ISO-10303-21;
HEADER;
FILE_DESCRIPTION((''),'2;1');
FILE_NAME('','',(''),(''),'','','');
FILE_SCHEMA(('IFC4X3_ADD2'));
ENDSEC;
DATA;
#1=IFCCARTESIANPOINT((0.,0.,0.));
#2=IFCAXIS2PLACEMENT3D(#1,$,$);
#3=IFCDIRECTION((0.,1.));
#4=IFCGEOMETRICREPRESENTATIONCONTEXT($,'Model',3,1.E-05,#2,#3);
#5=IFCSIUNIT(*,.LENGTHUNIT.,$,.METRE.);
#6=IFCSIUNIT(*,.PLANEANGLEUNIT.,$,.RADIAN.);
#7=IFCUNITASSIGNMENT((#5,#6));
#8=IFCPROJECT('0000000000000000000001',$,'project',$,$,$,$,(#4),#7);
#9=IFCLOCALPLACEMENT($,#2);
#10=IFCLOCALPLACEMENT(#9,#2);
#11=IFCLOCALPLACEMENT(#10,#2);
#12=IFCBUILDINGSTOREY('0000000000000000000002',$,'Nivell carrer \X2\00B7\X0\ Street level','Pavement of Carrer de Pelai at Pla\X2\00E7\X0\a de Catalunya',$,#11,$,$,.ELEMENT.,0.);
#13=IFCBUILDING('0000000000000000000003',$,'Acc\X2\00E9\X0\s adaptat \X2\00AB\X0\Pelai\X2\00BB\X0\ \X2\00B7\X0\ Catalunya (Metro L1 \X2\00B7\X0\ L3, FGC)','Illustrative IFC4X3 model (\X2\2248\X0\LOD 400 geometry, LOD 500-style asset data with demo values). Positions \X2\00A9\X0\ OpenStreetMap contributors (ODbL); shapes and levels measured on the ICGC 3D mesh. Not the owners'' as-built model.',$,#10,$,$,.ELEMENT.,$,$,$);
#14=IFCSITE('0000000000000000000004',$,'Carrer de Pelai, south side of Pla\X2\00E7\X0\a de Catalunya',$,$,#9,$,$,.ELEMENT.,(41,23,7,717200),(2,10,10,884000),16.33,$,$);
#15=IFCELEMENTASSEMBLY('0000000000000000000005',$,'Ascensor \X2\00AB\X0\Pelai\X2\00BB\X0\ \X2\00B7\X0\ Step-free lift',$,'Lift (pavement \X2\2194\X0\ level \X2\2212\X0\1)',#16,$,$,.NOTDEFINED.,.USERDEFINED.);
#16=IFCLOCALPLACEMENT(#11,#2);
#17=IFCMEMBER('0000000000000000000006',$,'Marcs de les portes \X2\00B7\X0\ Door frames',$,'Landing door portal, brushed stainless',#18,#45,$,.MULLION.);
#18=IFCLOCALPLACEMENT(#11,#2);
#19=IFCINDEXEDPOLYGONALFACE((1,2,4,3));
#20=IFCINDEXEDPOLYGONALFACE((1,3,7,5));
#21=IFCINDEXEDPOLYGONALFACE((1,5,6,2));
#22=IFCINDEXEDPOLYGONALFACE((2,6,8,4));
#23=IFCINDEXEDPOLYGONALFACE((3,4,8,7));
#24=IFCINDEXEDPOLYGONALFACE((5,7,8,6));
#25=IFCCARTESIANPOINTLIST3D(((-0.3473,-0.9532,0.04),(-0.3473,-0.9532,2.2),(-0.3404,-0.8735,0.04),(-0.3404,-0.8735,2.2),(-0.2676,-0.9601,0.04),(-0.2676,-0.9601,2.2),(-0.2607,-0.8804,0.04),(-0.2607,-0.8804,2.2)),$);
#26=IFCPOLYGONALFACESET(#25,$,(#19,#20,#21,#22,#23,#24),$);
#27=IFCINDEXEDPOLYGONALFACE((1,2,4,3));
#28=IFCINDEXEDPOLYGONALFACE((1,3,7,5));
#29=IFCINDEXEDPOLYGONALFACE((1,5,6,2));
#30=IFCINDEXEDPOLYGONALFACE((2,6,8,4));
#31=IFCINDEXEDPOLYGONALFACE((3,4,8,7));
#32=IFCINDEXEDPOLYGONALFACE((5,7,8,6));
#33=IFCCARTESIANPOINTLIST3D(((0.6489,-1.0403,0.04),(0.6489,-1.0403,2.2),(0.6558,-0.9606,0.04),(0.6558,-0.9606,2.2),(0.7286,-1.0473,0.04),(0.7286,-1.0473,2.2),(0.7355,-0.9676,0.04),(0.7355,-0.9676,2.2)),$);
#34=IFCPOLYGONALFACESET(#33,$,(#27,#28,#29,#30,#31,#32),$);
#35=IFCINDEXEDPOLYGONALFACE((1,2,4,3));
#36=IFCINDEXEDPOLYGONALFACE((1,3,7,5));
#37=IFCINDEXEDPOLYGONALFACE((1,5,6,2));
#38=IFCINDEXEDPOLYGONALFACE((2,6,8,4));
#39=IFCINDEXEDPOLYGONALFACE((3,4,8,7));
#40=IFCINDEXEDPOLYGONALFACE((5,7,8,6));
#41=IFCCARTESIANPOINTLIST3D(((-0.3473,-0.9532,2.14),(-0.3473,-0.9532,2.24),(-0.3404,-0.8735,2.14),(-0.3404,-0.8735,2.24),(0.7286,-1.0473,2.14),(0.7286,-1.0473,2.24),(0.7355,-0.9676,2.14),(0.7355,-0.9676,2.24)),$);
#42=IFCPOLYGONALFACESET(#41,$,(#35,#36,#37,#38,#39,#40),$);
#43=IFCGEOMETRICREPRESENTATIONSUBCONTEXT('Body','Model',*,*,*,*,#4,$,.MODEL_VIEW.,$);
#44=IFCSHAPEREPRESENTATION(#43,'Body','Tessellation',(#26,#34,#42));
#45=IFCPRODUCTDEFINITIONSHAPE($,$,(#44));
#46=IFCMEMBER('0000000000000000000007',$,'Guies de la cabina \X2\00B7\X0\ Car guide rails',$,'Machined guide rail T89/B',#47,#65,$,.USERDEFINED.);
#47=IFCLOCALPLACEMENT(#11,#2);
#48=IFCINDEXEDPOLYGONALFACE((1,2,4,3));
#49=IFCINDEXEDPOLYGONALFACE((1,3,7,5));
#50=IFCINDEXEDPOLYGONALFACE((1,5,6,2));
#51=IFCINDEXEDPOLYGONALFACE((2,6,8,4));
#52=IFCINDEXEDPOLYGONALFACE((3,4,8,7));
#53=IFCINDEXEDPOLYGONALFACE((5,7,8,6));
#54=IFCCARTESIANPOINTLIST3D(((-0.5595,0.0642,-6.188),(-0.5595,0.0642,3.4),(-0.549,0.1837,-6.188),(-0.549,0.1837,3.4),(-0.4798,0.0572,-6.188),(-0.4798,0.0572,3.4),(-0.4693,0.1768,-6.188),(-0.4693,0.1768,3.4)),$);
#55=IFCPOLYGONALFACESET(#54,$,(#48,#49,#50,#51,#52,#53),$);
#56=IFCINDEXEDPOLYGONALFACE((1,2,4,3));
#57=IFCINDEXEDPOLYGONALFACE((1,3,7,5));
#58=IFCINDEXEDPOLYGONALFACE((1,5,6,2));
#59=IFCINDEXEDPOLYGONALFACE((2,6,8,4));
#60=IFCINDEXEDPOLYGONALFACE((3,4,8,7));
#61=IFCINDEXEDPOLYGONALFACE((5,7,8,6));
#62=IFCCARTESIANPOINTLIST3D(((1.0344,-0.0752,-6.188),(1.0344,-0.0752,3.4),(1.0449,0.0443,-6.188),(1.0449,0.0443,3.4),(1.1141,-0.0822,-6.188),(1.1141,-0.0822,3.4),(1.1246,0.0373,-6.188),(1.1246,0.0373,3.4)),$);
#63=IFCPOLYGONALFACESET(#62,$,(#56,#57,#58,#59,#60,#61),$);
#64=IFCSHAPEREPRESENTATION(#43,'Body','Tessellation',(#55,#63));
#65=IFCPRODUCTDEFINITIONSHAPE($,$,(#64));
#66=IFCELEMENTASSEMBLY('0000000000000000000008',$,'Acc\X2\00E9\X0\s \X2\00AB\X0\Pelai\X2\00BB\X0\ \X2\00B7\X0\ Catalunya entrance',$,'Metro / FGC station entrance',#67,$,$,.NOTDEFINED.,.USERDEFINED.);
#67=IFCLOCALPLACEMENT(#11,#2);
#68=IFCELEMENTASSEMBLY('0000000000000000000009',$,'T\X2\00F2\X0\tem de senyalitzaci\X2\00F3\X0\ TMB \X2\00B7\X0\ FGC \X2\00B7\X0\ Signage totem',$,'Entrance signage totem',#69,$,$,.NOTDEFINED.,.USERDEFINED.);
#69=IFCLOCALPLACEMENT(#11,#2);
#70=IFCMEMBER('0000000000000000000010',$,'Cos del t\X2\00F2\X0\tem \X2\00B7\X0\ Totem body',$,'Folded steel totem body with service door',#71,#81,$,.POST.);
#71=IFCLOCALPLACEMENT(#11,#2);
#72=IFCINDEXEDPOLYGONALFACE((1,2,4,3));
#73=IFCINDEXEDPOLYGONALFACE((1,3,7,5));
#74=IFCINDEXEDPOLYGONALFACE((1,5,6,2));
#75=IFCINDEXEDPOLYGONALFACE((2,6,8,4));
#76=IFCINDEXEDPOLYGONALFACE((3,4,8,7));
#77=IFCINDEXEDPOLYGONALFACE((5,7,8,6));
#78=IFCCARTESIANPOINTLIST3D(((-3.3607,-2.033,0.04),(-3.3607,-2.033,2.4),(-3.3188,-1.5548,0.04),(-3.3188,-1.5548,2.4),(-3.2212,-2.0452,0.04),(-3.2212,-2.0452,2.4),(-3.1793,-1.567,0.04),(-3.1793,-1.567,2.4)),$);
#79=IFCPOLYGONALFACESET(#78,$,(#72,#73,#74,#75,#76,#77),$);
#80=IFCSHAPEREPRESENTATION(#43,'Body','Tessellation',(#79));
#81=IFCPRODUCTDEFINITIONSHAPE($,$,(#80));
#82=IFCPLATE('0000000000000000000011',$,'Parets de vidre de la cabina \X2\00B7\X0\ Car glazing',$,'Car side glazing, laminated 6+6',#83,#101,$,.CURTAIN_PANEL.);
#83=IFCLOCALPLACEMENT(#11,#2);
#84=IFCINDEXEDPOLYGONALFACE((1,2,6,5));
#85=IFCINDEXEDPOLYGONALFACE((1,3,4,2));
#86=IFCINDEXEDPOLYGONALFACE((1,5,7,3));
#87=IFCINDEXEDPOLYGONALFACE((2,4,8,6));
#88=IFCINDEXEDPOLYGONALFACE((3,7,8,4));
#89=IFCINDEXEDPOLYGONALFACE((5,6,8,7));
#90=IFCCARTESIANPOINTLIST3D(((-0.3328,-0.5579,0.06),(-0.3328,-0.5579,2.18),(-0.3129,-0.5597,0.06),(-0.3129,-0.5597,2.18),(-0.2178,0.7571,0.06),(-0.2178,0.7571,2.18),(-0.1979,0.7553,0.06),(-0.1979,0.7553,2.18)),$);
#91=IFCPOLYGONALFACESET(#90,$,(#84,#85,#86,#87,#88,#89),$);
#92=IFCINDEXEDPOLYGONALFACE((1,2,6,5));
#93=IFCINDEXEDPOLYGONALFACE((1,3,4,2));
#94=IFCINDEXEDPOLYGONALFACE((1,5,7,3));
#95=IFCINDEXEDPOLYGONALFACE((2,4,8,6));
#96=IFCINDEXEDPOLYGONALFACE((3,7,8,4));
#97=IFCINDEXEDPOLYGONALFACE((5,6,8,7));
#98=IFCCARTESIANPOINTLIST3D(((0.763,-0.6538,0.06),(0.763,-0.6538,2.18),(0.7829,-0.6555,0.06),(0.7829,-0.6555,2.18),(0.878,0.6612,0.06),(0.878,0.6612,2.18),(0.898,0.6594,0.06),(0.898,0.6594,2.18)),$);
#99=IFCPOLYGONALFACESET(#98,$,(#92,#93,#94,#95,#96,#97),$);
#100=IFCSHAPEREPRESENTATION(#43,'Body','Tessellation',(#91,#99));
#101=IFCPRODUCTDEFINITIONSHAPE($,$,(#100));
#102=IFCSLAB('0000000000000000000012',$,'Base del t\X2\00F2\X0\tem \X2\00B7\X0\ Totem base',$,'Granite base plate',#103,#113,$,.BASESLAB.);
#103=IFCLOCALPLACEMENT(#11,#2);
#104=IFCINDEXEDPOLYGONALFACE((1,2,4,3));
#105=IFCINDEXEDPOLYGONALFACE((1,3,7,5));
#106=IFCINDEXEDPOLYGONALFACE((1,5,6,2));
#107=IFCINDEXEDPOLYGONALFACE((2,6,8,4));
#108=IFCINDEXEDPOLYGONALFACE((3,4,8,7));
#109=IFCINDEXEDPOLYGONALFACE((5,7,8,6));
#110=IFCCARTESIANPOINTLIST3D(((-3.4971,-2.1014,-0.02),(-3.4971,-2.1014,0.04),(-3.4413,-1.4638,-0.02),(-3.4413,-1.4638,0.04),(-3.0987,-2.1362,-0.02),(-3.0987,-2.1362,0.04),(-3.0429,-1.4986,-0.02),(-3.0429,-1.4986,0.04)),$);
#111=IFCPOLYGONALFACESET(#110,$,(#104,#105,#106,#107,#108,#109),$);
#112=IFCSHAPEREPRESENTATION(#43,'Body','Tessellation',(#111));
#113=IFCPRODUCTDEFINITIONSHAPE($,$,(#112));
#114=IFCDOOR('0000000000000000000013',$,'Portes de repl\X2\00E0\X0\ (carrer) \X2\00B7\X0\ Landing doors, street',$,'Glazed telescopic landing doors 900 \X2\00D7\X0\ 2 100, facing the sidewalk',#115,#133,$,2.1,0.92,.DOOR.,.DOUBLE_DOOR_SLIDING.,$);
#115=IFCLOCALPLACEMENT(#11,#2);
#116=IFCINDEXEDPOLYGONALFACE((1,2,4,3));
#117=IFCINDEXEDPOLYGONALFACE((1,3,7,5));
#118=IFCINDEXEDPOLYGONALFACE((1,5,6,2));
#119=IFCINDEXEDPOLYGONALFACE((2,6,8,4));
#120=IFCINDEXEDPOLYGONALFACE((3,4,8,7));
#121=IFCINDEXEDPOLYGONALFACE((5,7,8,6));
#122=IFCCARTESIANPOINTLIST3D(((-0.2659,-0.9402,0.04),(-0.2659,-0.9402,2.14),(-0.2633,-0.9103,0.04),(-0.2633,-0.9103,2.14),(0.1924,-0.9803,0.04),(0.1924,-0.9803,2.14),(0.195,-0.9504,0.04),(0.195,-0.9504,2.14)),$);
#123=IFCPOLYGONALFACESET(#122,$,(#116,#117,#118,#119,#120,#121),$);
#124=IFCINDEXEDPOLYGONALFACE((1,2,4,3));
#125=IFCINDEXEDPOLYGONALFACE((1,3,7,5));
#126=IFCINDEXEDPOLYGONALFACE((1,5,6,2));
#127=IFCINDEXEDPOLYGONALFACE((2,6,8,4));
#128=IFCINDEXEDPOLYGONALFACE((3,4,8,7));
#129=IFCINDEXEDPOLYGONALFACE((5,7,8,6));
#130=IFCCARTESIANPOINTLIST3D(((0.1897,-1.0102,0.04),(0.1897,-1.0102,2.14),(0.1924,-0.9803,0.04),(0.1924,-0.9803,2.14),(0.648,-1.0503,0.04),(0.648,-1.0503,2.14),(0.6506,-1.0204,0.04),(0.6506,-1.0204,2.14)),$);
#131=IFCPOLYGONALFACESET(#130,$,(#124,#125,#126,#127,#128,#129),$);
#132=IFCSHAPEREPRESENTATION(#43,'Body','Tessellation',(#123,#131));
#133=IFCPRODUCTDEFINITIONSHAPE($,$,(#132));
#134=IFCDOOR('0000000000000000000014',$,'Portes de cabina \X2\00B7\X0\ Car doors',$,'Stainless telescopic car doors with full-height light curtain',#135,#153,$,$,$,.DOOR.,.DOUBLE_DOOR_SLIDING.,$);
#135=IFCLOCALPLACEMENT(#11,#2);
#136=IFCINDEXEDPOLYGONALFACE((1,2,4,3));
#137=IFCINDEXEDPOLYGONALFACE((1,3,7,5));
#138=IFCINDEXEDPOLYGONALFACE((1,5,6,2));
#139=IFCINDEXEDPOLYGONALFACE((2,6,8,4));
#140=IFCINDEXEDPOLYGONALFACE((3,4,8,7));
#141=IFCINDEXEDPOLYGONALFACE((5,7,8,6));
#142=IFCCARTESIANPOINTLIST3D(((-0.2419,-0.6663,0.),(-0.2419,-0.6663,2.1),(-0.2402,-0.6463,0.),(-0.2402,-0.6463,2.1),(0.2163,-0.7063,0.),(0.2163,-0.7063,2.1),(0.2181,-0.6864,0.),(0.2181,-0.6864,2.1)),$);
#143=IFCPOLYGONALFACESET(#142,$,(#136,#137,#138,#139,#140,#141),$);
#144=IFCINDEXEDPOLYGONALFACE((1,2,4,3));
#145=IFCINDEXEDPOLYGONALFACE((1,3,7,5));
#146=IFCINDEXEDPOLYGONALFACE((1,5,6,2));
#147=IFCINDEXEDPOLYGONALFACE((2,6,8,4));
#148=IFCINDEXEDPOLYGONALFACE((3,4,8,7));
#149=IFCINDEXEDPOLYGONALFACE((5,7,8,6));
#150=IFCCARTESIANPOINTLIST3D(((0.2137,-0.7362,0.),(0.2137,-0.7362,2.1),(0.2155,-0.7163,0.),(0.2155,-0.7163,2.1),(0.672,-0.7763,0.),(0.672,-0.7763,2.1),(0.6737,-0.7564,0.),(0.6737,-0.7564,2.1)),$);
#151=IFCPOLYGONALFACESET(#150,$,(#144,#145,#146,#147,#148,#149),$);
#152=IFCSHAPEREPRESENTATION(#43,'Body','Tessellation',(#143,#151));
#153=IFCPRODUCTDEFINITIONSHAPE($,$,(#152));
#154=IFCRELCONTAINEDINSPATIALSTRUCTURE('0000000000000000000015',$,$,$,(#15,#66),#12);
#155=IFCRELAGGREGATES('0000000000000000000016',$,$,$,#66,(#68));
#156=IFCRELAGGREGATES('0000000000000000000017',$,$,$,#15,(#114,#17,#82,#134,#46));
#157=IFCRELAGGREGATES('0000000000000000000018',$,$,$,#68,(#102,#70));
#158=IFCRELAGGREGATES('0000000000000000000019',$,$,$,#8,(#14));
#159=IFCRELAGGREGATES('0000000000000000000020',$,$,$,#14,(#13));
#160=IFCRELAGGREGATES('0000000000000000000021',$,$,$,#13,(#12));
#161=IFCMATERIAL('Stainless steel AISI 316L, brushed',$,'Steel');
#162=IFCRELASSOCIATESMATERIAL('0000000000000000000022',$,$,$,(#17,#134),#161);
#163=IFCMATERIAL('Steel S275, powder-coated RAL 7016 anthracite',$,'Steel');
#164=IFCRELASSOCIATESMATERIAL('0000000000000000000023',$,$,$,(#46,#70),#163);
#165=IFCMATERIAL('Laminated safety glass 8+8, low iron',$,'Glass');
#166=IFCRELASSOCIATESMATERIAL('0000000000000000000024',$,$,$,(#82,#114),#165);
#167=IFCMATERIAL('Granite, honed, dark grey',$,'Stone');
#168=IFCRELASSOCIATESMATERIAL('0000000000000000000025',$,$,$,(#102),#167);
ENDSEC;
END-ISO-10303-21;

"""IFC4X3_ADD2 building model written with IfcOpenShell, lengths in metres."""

from ifc_helpers import new_model, si_unit, direction, frame, frame_2d, origin, place, context, subcontext, project, spatial, rectangle, extrude, material, element, aggregate, save


model = new_model("IFC4X3_ADD2")

# Units and contexts
model_context = context("Model", 3, precision=1e-05, world=origin(), true_north=direction((0.0, 1.0)))
body_context = subcontext(model_context, "Body", "Model", "MODEL_VIEW")
ifc_project = project(units=[si_unit("LENGTHUNIT", "METRE"), si_unit("PLANEANGLEUNIT", "RADIAN")], contexts=[model_context])

# Site, building, storey
site_placement = place(None, origin())
site = spatial("IfcSite", under=ifc_project, at=site_placement, Name="Carrer de Pelai, south side of Plaça de Catalunya", CompositionType="ELEMENT", RefLatitude=(41, 23, 7, 717200), RefLongitude=(2, 10, 10, 884000), RefElevation=16.33)
building_placement = place(site_placement, origin())
building = spatial("IfcBuilding", under=site, at=building_placement, Name="Accés adaptat «Pelai» · Catalunya (Metro L1 · L3, FGC)", Description="Illustrative IFC4X3 model (≈LOD 400 geometry, LOD 500-style asset data with demo values). Positions © OpenStreetMap contributors (ODbL); shapes and levels measured on the ICGC 3D mesh. Not the owners' as-built model.", CompositionType="ELEMENT")
storey_placement = place(building_placement, origin())
storey = spatial("IfcBuildingStorey", under=building, at=storey_placement, Name="Nivell carrer · Street level", Description="Pavement of Carrer de Pelai at Plaça de Catalunya", CompositionType="ELEMENT", Elevation=0.0)

# Element assembly, members
assembly_1_placement = place(building_placement, origin())
assembly_1 = element("IfcElementAssembly", 1, at=assembly_1_placement, inside=storey, Name="Ascensor «Pelai» · Step-free lift", ObjectType="Lift (pavement ↔ level −1)", AssemblyPlace="NOTDEFINED", PredefinedType="USERDEFINED")
ifc_material_1 = material(Name="Stainless steel AISI 316L, brushed", Category="Steel")
member_1_placement = place(building_placement, origin())
member_1 = element("IfcMember", 2, at=member_1_placement, material=ifc_material_1, Name="Marcs de les portes · Door frames", ObjectType="Landing door portal, brushed stainless", PredefinedType="MULLION", context=body_context, shape_type="SweptSolid", body=[
    extrude(rectangle(XDim=0.08, YDim=0.08, at=frame_2d((0.0, 0.0), x_axis=(0.996195, -0.087156))), frame((-0.304, -0.9168, 0.04)), (0.0, 0.0, 1.0), 2.16),
    extrude(rectangle(XDim=0.08, YDim=0.08, at=frame_2d((0.0, 0.0), x_axis=(0.996195, -0.087156))), frame((0.6922, -1.004, 0.04)), (0.0, 0.0, 1.0), 2.16),
    extrude(rectangle(XDim=1.08, YDim=0.08, at=frame_2d((0.0, 0.0), x_axis=(0.996195, -0.087156))), frame((0.1941, -0.9604, 2.14)), (0.0, 0.0, 1.0), 0.1),
])
ifc_material_2 = material(Name="Steel S275, powder-coated RAL 7016 anthracite", Category="Steel")
member_2_placement = place(building_placement, origin())
member_2 = element("IfcMember", 3, at=member_2_placement, material=ifc_material_2, Name="Guies de la cabina · Car guide rails", ObjectType="Machined guide rail T89/B", PredefinedType="USERDEFINED", context=body_context, shape_type="SweptSolid", body=[
    extrude(rectangle(XDim=0.08, YDim=0.12, at=frame_2d((0.0, 0.0), x_axis=(0.996195, -0.087156))), frame((-0.5144, 0.1205, -6.188)), (0.0, 0.0, 1.0), 9.588),
    extrude(rectangle(XDim=0.08, YDim=0.12, at=frame_2d((0.0, 0.0), x_axis=(0.996195, -0.087156))), frame((1.0795, -0.019, -6.188)), (0.0, 0.0, 1.0), 9.588),
])

# Element assemblies, member
assembly_2_placement = place(building_placement, origin())
assembly_2 = element("IfcElementAssembly", 4, at=assembly_2_placement, inside=storey, Name="Accés «Pelai» · Catalunya entrance", ObjectType="Metro / FGC station entrance", AssemblyPlace="NOTDEFINED", PredefinedType="USERDEFINED")
assembly_3_placement = place(building_placement, origin())
assembly_3 = element("IfcElementAssembly", 5, at=assembly_3_placement, Name="Tòtem de senyalització TMB · FGC · Signage totem", ObjectType="Entrance signage totem", AssemblyPlace="NOTDEFINED", PredefinedType="USERDEFINED")
aggregate(assembly_2, [assembly_3])
member_3_placement = place(building_placement, origin())
member_3 = element("IfcMember", 6, at=member_3_placement, material=ifc_material_2, Name="Cos del tòtem · Totem body", ObjectType="Folded steel totem body with service door", PredefinedType="POST", context=body_context, shape_type="SweptSolid", body=[
    extrude(rectangle(XDim=0.14, YDim=0.48, at=frame_2d((0.0, 0.0), x_axis=(0.996195, -0.087156))), frame((-3.27, -1.8, 0.04)), (0.0, 0.0, 1.0), 2.36),
])

# Plate
ifc_material_3 = material(Name="Laminated safety glass 8+8, low iron", Category="Glass")
plate_placement = place(building_placement, origin())
plate = element("IfcPlate", 7, at=plate_placement, material=ifc_material_3, Name="Parets de vidre de la cabina · Car glazing", ObjectType="Car side glazing, laminated 6+6", PredefinedType="CURTAIN_PANEL", context=body_context, shape_type="SweptSolid", body=[
    extrude(rectangle(XDim=0.02, YDim=1.32, at=frame_2d((0.0, 0.0), x_axis=(0.996195, -0.087156))), frame((-0.2653, 0.0987, 0.06)), (0.0, 0.0, 1.0), 2.12),
    extrude(rectangle(XDim=0.02, YDim=1.32, at=frame_2d((0.0, 0.0), x_axis=(0.996195, -0.087156))), frame((0.8305, 0.0028, 0.06)), (0.0, 0.0, 1.0), 2.12),
])

# Slab
ifc_material_4 = material(Name="Granite, honed, dark grey", Category="Stone")
slab_placement = place(building_placement, origin())
slab = element("IfcSlab", 8, at=slab_placement, material=ifc_material_4, Name="Base del tòtem · Totem base", ObjectType="Granite base plate", PredefinedType="BASESLAB", context=body_context, shape_type="SweptSolid", body=[
    extrude(rectangle(XDim=0.4, YDim=0.64, at=frame_2d((0.0, 0.0), x_axis=(0.996195, -0.087156))), frame((-3.27, -1.8, -0.02)), (0.0, 0.0, 1.0), 0.06),
])

# Doors
door_1_placement = place(building_placement, origin())
door_1 = element("IfcDoor", 9, at=door_1_placement, material=ifc_material_3, Name="Portes de replà (carrer) · Landing doors, street", ObjectType="Glazed telescopic landing doors 900 × 2 100, facing the sidewalk", OperationType="DOUBLE_DOOR_SLIDING", OverallHeight=2.1, OverallWidth=0.92, PredefinedType="DOOR", context=body_context, shape_type="SweptSolid", body=[
    extrude(rectangle(XDim=0.46, YDim=0.03, at=frame_2d((0.0, 0.0), x_axis=(0.996195, -0.087156))), frame((-0.0355, -0.9453, 0.04)), (0.0, 0.0, 1.0), 2.1),
    extrude(rectangle(XDim=0.46, YDim=0.03, at=frame_2d((0.0, 0.0), x_axis=(0.996195, -0.087156))), frame((0.4202, -1.0153, 0.04)), (0.0, 0.0, 1.0), 2.1),
])
door_2_placement = place(building_placement, origin())
door_2 = element("IfcDoor", 10, at=door_2_placement, material=ifc_material_1, Name="Portes de cabina · Car doors", ObjectType="Stainless telescopic car doors with full-height light curtain", OperationType="DOUBLE_DOOR_SLIDING", PredefinedType="DOOR", context=body_context, shape_type="SweptSolid", body=[
    extrude(rectangle(XDim=0.46, YDim=0.02, at=frame_2d((0.0, 0.0), x_axis=(0.996195, -0.087156))), frame((-0.0119, -0.6763, 0.0)), (0.0, 0.0, 1.0), 2.1),
    extrude(rectangle(XDim=0.46, YDim=0.02, at=frame_2d((0.0, 0.0), x_axis=(0.996195, -0.087156))), frame((0.4437, -0.7463, 0.0)), (0.0, 0.0, 1.0), 2.1),
])

aggregate(assembly_1, [door_1, member_1, plate, door_2, member_2])

aggregate(assembly_3, [slab, member_3])

save(model, "model.ifc")
